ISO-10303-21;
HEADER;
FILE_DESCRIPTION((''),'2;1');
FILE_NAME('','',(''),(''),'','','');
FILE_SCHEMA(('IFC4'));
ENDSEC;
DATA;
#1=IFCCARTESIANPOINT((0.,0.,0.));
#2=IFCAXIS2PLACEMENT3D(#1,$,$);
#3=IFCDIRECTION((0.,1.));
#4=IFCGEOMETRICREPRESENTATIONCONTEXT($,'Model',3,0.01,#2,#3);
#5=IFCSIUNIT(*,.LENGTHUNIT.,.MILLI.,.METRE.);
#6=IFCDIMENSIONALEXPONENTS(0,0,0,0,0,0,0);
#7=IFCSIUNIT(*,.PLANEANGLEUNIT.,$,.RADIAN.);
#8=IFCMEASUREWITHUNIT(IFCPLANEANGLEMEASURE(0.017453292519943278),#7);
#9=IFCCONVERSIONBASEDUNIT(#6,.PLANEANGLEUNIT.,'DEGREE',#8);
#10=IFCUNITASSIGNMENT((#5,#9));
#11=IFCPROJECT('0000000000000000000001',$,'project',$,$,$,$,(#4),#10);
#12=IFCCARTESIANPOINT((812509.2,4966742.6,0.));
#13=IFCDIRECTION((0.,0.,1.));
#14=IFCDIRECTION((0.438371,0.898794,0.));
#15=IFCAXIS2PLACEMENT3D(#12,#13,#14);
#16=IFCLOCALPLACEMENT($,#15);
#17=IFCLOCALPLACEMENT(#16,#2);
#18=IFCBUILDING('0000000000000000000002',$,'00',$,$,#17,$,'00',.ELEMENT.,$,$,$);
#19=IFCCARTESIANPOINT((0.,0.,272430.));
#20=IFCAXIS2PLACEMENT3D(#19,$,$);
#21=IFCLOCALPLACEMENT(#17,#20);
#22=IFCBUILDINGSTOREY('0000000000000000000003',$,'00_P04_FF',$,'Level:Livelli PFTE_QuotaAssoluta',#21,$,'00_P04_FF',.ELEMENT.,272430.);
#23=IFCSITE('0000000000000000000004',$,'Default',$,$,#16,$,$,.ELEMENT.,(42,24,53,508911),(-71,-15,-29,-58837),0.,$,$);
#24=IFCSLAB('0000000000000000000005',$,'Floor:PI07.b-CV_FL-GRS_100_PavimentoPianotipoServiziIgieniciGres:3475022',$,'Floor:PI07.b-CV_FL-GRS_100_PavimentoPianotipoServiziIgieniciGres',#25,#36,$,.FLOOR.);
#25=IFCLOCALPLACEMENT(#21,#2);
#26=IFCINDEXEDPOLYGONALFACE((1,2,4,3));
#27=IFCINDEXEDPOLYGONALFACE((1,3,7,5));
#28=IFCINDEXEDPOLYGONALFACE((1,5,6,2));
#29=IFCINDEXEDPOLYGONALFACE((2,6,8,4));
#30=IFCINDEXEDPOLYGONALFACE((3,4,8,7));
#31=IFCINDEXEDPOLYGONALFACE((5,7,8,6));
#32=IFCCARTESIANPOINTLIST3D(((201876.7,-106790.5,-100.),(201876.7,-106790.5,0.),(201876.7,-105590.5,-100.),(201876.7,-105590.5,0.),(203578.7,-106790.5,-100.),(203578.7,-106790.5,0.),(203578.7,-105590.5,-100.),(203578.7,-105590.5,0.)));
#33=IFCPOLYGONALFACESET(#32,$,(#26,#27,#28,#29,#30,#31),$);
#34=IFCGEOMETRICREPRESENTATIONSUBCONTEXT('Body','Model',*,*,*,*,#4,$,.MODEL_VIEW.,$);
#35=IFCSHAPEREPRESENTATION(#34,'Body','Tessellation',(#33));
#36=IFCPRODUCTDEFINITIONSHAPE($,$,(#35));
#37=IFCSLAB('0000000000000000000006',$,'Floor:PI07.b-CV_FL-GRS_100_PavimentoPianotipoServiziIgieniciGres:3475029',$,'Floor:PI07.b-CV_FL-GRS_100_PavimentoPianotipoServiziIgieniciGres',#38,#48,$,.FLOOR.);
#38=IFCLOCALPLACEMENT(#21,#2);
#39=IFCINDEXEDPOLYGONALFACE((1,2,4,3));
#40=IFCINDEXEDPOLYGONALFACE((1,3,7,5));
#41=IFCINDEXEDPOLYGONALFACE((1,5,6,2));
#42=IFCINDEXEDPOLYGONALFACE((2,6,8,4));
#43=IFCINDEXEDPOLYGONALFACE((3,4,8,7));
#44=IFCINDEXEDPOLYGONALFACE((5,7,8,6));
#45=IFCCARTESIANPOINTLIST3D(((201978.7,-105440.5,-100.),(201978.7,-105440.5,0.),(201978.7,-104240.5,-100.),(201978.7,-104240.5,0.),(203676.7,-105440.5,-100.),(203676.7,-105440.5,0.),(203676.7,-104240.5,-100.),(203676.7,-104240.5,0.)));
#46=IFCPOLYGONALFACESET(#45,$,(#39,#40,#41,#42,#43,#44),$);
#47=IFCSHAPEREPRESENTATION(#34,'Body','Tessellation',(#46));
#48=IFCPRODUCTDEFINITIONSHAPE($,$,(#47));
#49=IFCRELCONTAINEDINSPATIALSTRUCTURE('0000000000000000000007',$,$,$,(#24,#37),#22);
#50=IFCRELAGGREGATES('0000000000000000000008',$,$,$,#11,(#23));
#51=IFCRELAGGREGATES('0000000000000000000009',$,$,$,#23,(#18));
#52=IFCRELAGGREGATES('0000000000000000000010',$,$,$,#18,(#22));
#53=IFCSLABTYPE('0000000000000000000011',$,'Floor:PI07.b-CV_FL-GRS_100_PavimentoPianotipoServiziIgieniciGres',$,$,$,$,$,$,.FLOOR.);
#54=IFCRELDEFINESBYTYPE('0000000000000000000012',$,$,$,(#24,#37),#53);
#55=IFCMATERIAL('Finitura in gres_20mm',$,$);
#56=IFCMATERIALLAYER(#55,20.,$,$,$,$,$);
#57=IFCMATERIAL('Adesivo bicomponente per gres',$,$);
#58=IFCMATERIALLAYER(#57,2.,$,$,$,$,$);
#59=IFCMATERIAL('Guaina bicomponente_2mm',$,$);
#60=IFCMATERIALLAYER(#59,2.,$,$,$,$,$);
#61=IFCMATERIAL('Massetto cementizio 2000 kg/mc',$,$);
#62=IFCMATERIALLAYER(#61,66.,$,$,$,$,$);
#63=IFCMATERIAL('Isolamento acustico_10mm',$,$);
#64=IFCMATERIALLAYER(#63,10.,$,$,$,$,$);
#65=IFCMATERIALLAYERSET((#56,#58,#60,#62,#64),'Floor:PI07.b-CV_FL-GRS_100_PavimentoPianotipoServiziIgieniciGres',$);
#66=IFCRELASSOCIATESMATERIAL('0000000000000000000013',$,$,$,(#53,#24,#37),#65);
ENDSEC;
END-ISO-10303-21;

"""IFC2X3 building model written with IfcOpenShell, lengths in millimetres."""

from ifc_helpers import new_model, entity, si_unit, converted_unit, direction, frame, frame_2d, origin, origin_2d_with_axis, place, context, subcontext, project, spatial, rectangle, extrude, material, layer, layer_set, layer_usage, type_object, element, save


model = new_model("IFC2X3")

# Units and contexts
model_context = context("Model", 3, precision=0.01, world=origin(), true_north=direction((0.0, 1.0)))
body_context = subcontext(model_context, "Body", "Model", "MODEL_VIEW")
ifc_project = project(units=[si_unit("LENGTHUNIT", "METRE", prefix="MILLI"), converted_unit("PLANEANGLEUNIT", "DEGREE", entity("IfcPlaneAngleMeasure", 0.017453292519943278), si_unit("PLANEANGLEUNIT", "RADIAN"), dimensions=[0, 0, 0, 0, 0, 0, 0])], contexts=[model_context])

# Site, building, storey
site_placement = place(None, frame((812509.2, 4966742.6, 0.0), z_axis=(0.0, 0.0, 1.0), x_axis=(0.438371, 0.898794, 0.0)))
site = spatial("IfcSite", under=ifc_project, at=site_placement, Name="Default", CompositionType="ELEMENT", RefLatitude=(42, 24, 53, 508911), RefLongitude=(-71, -15, -29, -58837), RefElevation=0.0)
building_placement = place(site_placement, origin())
building = spatial("IfcBuilding", under=site, at=building_placement, Name="00", LongName="00", CompositionType="ELEMENT")
storey_placement = place(building_placement, frame((0.0, 0.0, 272430.0)))
storey = spatial("IfcBuildingStorey", under=building, at=storey_placement, Name="00_P04_FF", ObjectType="Level:Livelli PFTE_QuotaAssoluta", LongName="00_P04_FF", CompositionType="ELEMENT", Elevation=272430.0)

# Slabs
ifc_material_1 = material(Name="Massetto cementizio 2000 kg/mc")
ifc_material_2 = material(Name="Isolamento acustico_10mm")
ifc_material_3 = material(Name="Finitura in gres_20mm")
ifc_layer_1 = layer(ifc_material_3, 20.0)
ifc_material_4 = material(Name="Adesivo bicomponente per gres")
ifc_layer_2 = layer(ifc_material_4, 2.0)
ifc_material_5 = material(Name="Guaina bicomponente_2mm")
ifc_layer_3 = layer(ifc_material_5, 2.0)
ifc_layer_4 = layer(ifc_material_1, 66.0)
ifc_layer_5 = layer(ifc_material_2, 10.0)
ifc_layer_set_1 = layer_set([ifc_layer_1, ifc_layer_2, ifc_layer_3, ifc_layer_4, ifc_layer_5], Name="Floor:PI07.b-CV_FL-GRS_100_PavimentoPianotipoServiziIgieniciGres")
slab_type_1 = type_object("IfcSlabType", Name="Floor:PI07.b-CV_FL-GRS_100_PavimentoPianotipoServiziIgieniciGres", PredefinedType="FLOOR", material=ifc_layer_set_1)
ifc_layer_usage_1 = layer_usage(ifc_layer_set_1, "AXIS3", "POSITIVE", 0.0)
slab_1_placement = place(storey_placement, origin())
element("IfcSlab", 1, at=slab_1_placement, inside=storey, type_object=slab_type_1, material=ifc_layer_usage_1, Name="Floor:PI07.b-CV_FL-GRS_100_PavimentoPianotipoServiziIgieniciGres:3475022", ObjectType="Floor:PI07.b-CV_FL-GRS_100_PavimentoPianotipoServiziIgieniciGres", PredefinedType="FLOOR", context=body_context, shape_type="SweptSolid", body=[
    extrude(rectangle(XDim=1200.0, YDim=1702.0, at=frame_2d((0.0, 0.0), x_axis=(1.0, 0.0))), frame((202727.7, -106190.5, 0.0), z_axis=(0.0, 0.0, -1.0), x_axis=(0.0, 1.0, 0.0)), (0.0, 0.0, 1.0), 100.0),
])
ifc_layer_usage_2 = layer_usage(ifc_layer_set_1, "AXIS3", "POSITIVE", 0.0)
slab_2_placement = place(storey_placement, origin())
element("IfcSlab", 2, at=slab_2_placement, inside=storey, type_object=slab_type_1, material=ifc_layer_usage_2, Name="Floor:PI07.b-CV_FL-GRS_100_PavimentoPianotipoServiziIgieniciGres:3475029", ObjectType="Floor:PI07.b-CV_FL-GRS_100_PavimentoPianotipoServiziIgieniciGres", PredefinedType="FLOOR", context=body_context, shape_type="SweptSolid", body=[
    extrude(rectangle(XDim=1200.0, YDim=1698.0, at=origin_2d_with_axis()), frame((202827.7, -104840.5, 0.0), z_axis=(0.0, 0.0, -1.0), x_axis=(0.0, 1.0, 0.0)), (0.0, 0.0, 1.0), 100.0),
])

save(model, "model.ifc")
